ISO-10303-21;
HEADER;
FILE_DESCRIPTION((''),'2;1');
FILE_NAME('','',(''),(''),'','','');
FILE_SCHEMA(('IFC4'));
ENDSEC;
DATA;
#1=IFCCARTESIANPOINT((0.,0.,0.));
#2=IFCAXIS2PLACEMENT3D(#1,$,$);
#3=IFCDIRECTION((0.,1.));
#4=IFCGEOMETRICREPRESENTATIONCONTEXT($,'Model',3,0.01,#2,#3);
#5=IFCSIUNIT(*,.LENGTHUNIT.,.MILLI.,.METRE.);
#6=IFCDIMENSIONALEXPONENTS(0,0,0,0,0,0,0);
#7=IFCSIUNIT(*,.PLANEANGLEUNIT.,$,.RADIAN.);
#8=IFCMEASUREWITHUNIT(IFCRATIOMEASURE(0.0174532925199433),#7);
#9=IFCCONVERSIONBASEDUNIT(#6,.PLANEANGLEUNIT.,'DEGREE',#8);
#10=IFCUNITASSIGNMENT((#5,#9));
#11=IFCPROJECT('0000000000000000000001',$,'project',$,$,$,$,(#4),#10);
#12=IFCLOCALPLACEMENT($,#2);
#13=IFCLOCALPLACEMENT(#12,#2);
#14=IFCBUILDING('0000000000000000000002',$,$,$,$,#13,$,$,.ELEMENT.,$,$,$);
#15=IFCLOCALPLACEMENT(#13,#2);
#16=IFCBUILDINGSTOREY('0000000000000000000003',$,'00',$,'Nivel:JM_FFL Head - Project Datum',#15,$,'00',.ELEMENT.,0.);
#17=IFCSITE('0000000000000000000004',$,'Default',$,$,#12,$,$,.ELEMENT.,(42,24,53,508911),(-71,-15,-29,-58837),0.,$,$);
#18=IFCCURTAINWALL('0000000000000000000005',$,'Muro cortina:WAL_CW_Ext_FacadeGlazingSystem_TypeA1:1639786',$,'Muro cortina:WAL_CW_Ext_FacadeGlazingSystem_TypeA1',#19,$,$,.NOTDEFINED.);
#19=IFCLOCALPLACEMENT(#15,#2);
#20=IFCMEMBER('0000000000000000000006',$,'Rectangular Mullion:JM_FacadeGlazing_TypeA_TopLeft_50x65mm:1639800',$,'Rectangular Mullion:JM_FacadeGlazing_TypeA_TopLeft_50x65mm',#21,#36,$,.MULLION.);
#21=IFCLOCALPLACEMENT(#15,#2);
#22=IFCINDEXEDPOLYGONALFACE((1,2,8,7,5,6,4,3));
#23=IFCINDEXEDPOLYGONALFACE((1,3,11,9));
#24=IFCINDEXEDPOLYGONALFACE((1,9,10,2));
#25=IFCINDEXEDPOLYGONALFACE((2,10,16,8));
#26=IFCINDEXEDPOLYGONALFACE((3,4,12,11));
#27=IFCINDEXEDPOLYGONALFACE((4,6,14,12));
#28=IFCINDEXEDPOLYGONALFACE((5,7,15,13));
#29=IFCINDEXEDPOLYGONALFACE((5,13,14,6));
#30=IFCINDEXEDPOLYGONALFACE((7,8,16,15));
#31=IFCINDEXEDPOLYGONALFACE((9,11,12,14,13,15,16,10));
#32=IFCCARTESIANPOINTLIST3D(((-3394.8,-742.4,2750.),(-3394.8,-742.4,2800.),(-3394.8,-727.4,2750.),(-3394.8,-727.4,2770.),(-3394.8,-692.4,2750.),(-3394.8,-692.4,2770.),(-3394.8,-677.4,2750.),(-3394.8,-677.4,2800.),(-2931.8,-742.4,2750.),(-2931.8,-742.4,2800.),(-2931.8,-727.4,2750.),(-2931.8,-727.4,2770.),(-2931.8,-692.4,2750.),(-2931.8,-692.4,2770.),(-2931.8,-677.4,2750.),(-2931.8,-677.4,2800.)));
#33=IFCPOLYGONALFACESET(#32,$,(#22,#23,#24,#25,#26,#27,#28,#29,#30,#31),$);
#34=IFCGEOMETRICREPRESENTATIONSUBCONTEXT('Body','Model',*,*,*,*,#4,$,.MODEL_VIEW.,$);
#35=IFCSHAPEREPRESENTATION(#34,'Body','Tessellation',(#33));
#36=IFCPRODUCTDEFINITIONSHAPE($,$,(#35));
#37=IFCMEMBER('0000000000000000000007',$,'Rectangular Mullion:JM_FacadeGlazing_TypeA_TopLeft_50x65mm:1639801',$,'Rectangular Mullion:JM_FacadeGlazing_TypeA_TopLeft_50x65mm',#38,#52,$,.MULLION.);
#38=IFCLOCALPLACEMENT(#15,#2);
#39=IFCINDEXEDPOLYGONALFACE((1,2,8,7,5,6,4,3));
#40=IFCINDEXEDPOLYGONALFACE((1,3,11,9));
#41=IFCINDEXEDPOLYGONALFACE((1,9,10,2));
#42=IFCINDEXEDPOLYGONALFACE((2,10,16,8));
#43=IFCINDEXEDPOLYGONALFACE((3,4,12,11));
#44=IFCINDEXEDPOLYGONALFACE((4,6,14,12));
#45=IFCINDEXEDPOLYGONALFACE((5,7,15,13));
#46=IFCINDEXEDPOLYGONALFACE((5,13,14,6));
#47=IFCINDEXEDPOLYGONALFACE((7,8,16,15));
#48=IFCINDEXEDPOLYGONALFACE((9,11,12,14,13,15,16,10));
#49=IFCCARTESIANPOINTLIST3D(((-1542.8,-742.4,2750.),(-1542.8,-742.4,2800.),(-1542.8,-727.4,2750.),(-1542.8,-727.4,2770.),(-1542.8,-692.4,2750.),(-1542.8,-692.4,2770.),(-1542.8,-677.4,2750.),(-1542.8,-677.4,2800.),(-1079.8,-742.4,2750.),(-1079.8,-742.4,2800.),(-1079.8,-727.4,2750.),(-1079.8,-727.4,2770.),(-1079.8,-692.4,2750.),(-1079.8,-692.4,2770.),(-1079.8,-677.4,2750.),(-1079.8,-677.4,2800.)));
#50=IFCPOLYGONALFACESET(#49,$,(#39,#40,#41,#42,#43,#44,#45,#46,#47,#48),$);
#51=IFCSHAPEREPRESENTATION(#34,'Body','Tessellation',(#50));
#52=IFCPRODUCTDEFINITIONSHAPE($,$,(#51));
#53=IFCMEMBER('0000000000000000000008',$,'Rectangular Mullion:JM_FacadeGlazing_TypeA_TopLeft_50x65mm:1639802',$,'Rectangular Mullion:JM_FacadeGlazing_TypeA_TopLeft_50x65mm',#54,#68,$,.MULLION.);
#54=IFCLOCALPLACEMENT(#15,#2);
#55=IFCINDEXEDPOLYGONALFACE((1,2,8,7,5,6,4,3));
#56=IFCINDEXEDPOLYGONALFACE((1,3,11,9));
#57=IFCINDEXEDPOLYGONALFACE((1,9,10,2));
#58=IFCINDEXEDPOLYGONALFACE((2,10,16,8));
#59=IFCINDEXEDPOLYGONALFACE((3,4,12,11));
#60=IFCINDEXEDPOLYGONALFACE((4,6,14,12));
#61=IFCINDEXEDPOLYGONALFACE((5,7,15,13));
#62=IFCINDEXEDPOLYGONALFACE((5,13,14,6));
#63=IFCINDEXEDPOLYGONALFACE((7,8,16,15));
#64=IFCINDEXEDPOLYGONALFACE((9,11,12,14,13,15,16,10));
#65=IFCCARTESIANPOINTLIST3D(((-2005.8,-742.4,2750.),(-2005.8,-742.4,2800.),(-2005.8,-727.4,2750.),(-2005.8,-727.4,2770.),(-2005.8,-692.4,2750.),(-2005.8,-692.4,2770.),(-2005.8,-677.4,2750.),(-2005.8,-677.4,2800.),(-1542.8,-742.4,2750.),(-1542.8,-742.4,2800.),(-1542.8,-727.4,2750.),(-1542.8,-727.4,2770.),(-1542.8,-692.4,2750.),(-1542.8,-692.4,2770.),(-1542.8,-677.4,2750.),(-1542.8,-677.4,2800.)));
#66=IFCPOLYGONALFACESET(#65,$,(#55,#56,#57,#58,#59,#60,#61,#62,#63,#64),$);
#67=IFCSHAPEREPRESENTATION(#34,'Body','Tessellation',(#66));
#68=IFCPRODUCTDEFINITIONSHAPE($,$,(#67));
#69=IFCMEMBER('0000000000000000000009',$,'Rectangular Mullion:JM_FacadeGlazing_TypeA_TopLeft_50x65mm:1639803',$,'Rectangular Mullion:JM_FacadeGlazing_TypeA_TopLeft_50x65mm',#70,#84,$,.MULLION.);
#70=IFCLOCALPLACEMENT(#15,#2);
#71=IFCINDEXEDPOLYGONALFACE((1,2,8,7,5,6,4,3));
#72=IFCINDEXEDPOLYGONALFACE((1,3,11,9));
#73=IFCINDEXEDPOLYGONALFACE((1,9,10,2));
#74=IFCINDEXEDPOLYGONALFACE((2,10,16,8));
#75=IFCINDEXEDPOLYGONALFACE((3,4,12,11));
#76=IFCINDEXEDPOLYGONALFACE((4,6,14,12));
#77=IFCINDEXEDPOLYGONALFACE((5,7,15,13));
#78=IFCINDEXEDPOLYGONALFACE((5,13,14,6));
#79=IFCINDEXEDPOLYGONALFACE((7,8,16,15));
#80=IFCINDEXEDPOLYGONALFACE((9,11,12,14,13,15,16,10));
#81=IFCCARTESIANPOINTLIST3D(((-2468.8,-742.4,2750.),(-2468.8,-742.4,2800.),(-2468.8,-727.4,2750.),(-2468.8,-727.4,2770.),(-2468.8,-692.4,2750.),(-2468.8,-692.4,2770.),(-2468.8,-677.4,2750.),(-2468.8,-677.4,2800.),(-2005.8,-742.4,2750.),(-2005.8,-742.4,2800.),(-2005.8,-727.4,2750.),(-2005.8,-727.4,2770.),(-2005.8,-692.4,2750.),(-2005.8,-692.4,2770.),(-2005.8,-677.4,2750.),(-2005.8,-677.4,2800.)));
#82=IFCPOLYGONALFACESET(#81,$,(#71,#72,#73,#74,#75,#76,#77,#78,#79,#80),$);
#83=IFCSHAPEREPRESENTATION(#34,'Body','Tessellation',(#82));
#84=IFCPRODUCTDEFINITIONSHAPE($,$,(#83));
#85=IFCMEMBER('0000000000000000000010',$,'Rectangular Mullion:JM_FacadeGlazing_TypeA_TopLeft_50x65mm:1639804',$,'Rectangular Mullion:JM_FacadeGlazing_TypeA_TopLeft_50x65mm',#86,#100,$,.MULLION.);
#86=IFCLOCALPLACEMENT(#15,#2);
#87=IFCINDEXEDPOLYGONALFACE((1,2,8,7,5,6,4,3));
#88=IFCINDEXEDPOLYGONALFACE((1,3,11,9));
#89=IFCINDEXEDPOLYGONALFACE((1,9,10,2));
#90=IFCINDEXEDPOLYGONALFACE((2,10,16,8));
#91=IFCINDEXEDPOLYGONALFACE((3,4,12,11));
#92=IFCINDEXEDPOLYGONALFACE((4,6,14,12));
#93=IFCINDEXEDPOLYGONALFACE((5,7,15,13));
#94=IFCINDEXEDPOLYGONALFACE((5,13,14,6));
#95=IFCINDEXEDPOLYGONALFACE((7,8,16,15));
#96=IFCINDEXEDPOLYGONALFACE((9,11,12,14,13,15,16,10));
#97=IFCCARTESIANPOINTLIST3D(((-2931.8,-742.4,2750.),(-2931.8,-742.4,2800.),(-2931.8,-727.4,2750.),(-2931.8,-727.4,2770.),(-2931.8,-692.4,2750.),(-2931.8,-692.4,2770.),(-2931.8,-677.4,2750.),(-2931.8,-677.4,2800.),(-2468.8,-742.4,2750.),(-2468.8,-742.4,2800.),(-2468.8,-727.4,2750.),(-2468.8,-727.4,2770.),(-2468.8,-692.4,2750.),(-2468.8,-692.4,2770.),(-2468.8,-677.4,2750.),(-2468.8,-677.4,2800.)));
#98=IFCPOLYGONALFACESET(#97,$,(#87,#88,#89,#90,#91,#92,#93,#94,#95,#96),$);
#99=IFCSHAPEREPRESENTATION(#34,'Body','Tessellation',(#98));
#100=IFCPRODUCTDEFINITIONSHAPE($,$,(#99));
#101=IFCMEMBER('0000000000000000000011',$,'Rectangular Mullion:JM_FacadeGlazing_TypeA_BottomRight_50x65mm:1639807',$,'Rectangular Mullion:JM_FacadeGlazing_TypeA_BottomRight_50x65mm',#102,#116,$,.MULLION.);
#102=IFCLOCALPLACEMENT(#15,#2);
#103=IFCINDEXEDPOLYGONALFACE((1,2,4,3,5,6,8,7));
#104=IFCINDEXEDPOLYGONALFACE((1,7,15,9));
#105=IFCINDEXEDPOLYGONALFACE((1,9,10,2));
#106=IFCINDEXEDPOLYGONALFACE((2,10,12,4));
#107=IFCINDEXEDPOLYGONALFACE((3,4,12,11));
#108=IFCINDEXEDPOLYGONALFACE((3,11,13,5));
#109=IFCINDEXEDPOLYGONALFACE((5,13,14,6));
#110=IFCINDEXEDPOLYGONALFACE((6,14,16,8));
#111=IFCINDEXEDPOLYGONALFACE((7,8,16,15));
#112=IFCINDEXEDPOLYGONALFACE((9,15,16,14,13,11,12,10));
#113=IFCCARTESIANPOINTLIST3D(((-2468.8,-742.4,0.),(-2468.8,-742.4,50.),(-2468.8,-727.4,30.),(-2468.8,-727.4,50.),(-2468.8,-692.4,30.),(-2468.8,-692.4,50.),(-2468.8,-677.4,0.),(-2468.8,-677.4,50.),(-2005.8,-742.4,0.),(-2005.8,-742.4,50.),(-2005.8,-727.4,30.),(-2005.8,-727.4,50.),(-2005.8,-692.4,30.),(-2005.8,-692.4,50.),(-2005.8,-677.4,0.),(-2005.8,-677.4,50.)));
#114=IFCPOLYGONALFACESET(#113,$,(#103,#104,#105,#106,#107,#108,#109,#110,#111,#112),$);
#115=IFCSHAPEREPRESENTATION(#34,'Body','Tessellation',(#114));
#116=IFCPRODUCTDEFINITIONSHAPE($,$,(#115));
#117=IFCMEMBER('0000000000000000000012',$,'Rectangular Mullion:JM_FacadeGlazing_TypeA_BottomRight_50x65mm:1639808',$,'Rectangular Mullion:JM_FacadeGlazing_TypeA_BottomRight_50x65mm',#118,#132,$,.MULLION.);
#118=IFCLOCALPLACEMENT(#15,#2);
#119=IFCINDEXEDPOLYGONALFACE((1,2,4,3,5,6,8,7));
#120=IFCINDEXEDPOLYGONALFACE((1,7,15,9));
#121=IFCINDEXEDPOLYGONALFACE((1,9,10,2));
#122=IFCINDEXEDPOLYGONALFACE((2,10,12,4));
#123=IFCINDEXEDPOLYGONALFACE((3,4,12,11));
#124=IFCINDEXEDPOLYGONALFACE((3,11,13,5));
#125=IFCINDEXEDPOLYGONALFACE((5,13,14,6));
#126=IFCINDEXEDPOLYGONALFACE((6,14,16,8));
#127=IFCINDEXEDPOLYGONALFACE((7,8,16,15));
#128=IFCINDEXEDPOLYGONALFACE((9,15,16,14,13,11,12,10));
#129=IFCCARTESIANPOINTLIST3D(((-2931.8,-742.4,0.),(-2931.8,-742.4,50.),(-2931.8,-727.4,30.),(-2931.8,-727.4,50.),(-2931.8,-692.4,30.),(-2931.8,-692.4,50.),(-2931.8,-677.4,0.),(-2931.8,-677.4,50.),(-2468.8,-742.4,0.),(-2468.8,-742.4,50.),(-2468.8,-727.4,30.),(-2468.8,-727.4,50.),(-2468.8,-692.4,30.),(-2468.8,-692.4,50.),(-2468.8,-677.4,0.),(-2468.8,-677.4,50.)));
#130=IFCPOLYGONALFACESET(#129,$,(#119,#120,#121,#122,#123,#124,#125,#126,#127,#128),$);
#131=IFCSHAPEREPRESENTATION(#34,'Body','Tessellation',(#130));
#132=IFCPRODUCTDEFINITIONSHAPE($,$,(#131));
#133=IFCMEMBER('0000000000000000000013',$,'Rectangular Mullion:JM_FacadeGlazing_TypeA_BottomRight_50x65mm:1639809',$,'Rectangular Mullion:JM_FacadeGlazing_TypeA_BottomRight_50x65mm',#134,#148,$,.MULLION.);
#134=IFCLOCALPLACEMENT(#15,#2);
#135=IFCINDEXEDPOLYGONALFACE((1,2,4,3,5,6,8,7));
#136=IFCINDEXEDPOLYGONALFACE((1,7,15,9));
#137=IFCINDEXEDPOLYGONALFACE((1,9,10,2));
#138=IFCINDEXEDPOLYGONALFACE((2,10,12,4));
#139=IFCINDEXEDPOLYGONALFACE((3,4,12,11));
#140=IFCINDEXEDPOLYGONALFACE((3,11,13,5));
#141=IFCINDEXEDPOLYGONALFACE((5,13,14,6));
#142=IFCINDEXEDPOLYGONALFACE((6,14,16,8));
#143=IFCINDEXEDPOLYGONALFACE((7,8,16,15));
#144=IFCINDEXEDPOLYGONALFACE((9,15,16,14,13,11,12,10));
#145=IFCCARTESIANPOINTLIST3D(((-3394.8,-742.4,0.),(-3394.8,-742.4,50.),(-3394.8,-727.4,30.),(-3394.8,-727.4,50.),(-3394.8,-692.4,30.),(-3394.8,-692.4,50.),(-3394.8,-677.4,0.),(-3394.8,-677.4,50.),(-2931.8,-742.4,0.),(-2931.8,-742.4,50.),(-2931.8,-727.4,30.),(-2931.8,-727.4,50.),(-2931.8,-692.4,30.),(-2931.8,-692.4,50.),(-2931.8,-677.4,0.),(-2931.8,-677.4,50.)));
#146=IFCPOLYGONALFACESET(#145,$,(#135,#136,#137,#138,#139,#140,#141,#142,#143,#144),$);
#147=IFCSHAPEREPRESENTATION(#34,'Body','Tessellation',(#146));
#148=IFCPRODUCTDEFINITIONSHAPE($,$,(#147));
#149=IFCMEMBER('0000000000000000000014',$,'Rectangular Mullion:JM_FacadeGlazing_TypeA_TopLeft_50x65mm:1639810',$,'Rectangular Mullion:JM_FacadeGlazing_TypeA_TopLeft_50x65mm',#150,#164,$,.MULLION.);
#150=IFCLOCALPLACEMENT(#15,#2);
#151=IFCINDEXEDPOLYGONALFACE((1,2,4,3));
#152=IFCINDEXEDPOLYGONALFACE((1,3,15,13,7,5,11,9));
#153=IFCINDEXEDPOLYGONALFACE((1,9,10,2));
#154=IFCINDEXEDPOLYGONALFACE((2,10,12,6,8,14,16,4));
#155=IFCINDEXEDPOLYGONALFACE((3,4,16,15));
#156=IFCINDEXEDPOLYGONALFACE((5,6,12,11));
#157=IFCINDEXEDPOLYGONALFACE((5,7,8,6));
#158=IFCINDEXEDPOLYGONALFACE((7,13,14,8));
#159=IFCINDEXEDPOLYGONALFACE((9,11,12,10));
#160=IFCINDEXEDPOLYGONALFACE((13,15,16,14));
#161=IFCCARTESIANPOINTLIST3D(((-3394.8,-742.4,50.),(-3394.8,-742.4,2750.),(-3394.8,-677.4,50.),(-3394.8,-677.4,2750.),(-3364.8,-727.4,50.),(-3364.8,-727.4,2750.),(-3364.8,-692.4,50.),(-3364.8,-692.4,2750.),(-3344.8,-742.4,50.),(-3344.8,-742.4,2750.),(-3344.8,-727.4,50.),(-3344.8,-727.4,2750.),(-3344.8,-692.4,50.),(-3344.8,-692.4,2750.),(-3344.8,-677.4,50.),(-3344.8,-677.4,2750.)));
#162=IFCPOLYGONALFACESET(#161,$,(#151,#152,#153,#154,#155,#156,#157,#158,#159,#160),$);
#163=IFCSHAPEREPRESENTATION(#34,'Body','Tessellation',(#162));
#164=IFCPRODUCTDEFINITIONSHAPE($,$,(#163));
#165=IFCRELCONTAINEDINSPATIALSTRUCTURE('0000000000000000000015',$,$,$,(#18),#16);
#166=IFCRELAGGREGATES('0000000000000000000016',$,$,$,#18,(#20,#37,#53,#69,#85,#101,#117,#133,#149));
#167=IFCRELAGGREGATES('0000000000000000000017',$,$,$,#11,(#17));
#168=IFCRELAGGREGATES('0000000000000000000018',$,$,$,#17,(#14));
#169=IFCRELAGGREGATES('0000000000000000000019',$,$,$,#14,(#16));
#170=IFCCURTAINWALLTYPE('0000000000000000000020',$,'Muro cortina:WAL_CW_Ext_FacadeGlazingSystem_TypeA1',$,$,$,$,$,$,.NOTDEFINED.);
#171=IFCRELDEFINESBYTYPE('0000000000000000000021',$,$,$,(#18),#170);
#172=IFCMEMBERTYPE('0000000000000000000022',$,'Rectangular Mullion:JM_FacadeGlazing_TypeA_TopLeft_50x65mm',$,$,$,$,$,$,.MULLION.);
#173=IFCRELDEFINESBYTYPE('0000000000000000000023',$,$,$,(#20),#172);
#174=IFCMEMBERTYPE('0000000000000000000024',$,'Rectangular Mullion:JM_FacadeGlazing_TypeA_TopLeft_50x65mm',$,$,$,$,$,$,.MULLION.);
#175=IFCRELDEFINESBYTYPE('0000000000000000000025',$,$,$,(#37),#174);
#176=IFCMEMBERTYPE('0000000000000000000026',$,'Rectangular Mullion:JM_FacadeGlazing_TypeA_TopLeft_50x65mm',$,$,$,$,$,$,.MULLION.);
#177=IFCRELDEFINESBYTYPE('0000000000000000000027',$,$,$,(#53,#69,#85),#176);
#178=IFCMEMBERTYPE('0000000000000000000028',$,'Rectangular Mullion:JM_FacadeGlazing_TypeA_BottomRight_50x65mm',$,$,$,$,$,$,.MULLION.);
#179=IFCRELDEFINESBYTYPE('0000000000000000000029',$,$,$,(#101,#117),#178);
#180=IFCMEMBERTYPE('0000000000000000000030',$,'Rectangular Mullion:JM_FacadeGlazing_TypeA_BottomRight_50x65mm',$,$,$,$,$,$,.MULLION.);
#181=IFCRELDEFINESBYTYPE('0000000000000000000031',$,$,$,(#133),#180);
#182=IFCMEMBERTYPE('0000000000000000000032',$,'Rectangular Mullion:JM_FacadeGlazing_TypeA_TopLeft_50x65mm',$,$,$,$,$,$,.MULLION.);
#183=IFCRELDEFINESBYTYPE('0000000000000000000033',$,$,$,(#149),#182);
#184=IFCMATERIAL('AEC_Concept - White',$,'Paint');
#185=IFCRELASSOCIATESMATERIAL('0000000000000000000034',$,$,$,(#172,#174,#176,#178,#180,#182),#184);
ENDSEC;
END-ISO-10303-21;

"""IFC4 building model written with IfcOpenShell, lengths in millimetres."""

from ifc_helpers import new_model, entity, si_unit, converted_unit, direction, frame, origin, place, context, subcontext, project, spatial, indexed_curve, outline, extrude, source, transform, mapped, material, type_object, type_shapes, element, aggregate, save


model = new_model("IFC4")

# Units and contexts
model_context = context("Model", 3, precision=0.01, world=origin(), true_north=direction((0.0, 1.0)))
body_context = subcontext(model_context, "Body", "Model", "MODEL_VIEW")
ifc_project = project(units=[si_unit("LENGTHUNIT", "METRE", prefix="MILLI"), converted_unit("PLANEANGLEUNIT", "DEGREE", entity("IfcRatioMeasure", 0.0174532925199433), si_unit("PLANEANGLEUNIT", "RADIAN"), dimensions=[0, 0, 0, 0, 0, 0, 0])], contexts=[model_context])

# Site, building, storey
site_placement = place(None, origin())
site = spatial("IfcSite", under=ifc_project, at=site_placement, Name="Default", CompositionType="ELEMENT", RefLatitude=(42, 24, 53, 508911), RefLongitude=(-71, -15, -29, -58837), RefElevation=0.0)
building_placement = place(site_placement, origin())
building = spatial("IfcBuilding", under=site, at=building_placement, CompositionType="ELEMENT")
storey_placement = place(building_placement, origin())
storey = spatial("IfcBuildingStorey", under=building, at=storey_placement, Name="00", ObjectType="Nivel:JM_FFL Head - Project Datum", LongName="00", CompositionType="ELEMENT", Elevation=0.0)

# Curtain wall, members
curtain_wall_type = type_object("IfcCurtainWallType", Name="Muro cortina:WAL_CW_Ext_FacadeGlazingSystem_TypeA1", PredefinedType="NOTDEFINED")
curtain_wall_1_placement = place(storey_placement, origin())
curtain_wall_1 = element("IfcCurtainWall", 1, at=curtain_wall_1_placement, inside=storey, type_object=curtain_wall_type, Name="Muro cortina:WAL_CW_Ext_FacadeGlazingSystem_TypeA1:1639786", ObjectType="Muro cortina:WAL_CW_Ext_FacadeGlazingSystem_TypeA1", PredefinedType="NOTDEFINED")
ifc_material_1 = material(Name="AEC_Concept - White", Category="Paint")
member_type_1 = type_object("IfcMemberType", Name="Rectangular Mullion:JM_FacadeGlazing_TypeA_TopLeft_50x65mm", PredefinedType="MULLION", material=ifc_material_1)
shared_shape_1 = source(origin(), body_context, "Body", "SweptSolid", [
    extrude(outline(indexed_curve([(-32.5, -17.5), (-17.5, -17.5), (-17.5, 2.5), (17.5, 2.5), (17.5, -17.5), (32.5, -17.5), (32.5, 32.5), (-32.5, 32.5), (-32.5, -17.5)], self_intersect=False)), frame((-32.5, -32.5, -463.0), z_axis=(0.0, 0.0, 1.0), x_axis=(0.0, -1.0, 0.0)), (0.0, 0.0, 1.0), 463.0),
])
type_shapes(member_type_1, [shared_shape_1])
member_1_placement = place(curtain_wall_1_placement, frame((-3394.8, -677.4, 2800.0), z_axis=(-1.0, 0.0, 0.0), x_axis=(0.0, 0.0, 1.0)))
member_1 = element("IfcMember", 2, at=member_1_placement, type_object=member_type_1, Name="Rectangular Mullion:JM_FacadeGlazing_TypeA_TopLeft_50x65mm:1639800", ObjectType="Rectangular Mullion:JM_FacadeGlazing_TypeA_TopLeft_50x65mm", PredefinedType="MULLION", context=body_context, shape_type="MappedRepresentation", body=[
    mapped(shared_shape_1, transform((0.0, 0.0, 0.0), scale=1.0)),
])
member_type_2 = type_object("IfcMemberType", Name="Rectangular Mullion:JM_FacadeGlazing_TypeA_TopLeft_50x65mm", PredefinedType="MULLION", material=ifc_material_1)
shared_shape_2 = source(origin(), body_context, "Body", "SweptSolid", [
    extrude(outline(indexed_curve([(-32.5, -17.5), (-17.5, -17.5), (-17.5, 2.5), (17.5, 2.5), (17.5, -17.5), (32.5, -17.5), (32.5, 32.5), (-32.5, 32.5), (-32.5, -17.5)], self_intersect=False)), frame((-32.5, -32.5, -463.0), z_axis=(0.0, 0.0, 1.0), x_axis=(0.0, -1.0, 0.0)), (0.0, 0.0, 1.0), 463.0),
])
type_shapes(member_type_2, [shared_shape_2])
member_2_placement = place(curtain_wall_1_placement, frame((-1542.8, -677.4, 2800.0), z_axis=(-1.0, 0.0, 0.0), x_axis=(0.0, 0.0, 1.0)))
member_2 = element("IfcMember", 3, at=member_2_placement, type_object=member_type_2, Name="Rectangular Mullion:JM_FacadeGlazing_TypeA_TopLeft_50x65mm:1639801", ObjectType="Rectangular Mullion:JM_FacadeGlazing_TypeA_TopLeft_50x65mm", PredefinedType="MULLION", context=body_context, shape_type="MappedRepresentation", body=[
    mapped(shared_shape_2, transform((0.0, 0.0, 0.0), scale=1.0)),
])
member_type_3 = type_object("IfcMemberType", Name="Rectangular Mullion:JM_FacadeGlazing_TypeA_TopLeft_50x65mm", PredefinedType="MULLION", material=ifc_material_1)
shared_shape_3 = source(origin(), body_context, "Body", "SweptSolid", [
    extrude(outline(indexed_curve([(-32.5, -17.5), (-17.5, -17.5), (-17.5, 2.5), (17.5, 2.5), (17.5, -17.5), (32.5, -17.5), (32.5, 32.5), (-32.5, 32.5), (-32.5, -17.5)], self_intersect=False)), frame((-32.5, -32.5, -463.0), z_axis=(0.0, 0.0, 1.0), x_axis=(0.0, -1.0, 0.0)), (0.0, 0.0, 1.0), 463.0),
])
type_shapes(member_type_3, [shared_shape_3])
member_3_placement = place(curtain_wall_1_placement, frame((-2005.8, -677.4, 2800.0), z_axis=(-1.0, 0.0, 0.0), x_axis=(0.0, 0.0, 1.0)))
member_3 = element("IfcMember", 4, at=member_3_placement, type_object=member_type_3, Name="Rectangular Mullion:JM_FacadeGlazing_TypeA_TopLeft_50x65mm:1639802", ObjectType="Rectangular Mullion:JM_FacadeGlazing_TypeA_TopLeft_50x65mm", PredefinedType="MULLION", context=body_context, shape_type="MappedRepresentation", body=[
    mapped(shared_shape_3, transform((0.0, 0.0, 0.0), scale=1.0)),
])
member_4_placement = place(curtain_wall_1_placement, frame((-2468.8, -677.4, 2800.0), z_axis=(-1.0, 0.0, 0.0), x_axis=(0.0, 0.0, 1.0)))
member_4 = element("IfcMember", 5, at=member_4_placement, type_object=member_type_3, Name="Rectangular Mullion:JM_FacadeGlazing_TypeA_TopLeft_50x65mm:1639803", ObjectType="Rectangular Mullion:JM_FacadeGlazing_TypeA_TopLeft_50x65mm", PredefinedType="MULLION", context=body_context, shape_type="MappedRepresentation", body=[
    mapped(shared_shape_3, transform((0.0, 0.0, 0.0), scale=1.0)),
])
member_5_placement = place(curtain_wall_1_placement, frame((-2931.8, -677.4, 2800.0), z_axis=(-1.0, 0.0, 0.0), x_axis=(0.0, 0.0, 1.0)))
member_5 = element("IfcMember", 6, at=member_5_placement, type_object=member_type_3, Name="Rectangular Mullion:JM_FacadeGlazing_TypeA_TopLeft_50x65mm:1639804", ObjectType="Rectangular Mullion:JM_FacadeGlazing_TypeA_TopLeft_50x65mm", PredefinedType="MULLION", context=body_context, shape_type="MappedRepresentation", body=[
    mapped(shared_shape_3, transform((0.0, 0.0, 0.0), scale=1.0)),
])
member_type_4 = type_object("IfcMemberType", Name="Rectangular Mullion:JM_FacadeGlazing_TypeA_BottomRight_50x65mm", PredefinedType="MULLION", material=ifc_material_1)
shared_shape_4 = source(origin(), body_context, "Body", "SweptSolid", [
    extrude(outline(indexed_curve([(-32.5, -17.5), (-17.5, -17.5), (-17.5, 2.5), (17.5, 2.5), (17.5, -17.5), (32.5, -17.5), (32.5, 32.5), (-32.5, 32.5), (-32.5, -17.5)], self_intersect=False)), frame((-32.5, -32.5, -463.0), z_axis=(0.0, 0.0, 1.0), x_axis=(0.0, -1.0, 0.0)), (0.0, 0.0, 1.0), 463.0),
])
type_shapes(member_type_4, [shared_shape_4])
member_6_placement = place(curtain_wall_1_placement, frame((-2005.8, -677.4, 0.0), z_axis=(1.0, 0.0, 0.0), x_axis=(0.0, 0.0, -1.0)))
member_6 = element("IfcMember", 7, at=member_6_placement, type_object=member_type_4, Name="Rectangular Mullion:JM_FacadeGlazing_TypeA_BottomRight_50x65mm:1639807", ObjectType="Rectangular Mullion:JM_FacadeGlazing_TypeA_BottomRight_50x65mm", PredefinedType="MULLION", context=body_context, shape_type="MappedRepresentation", body=[
    mapped(shared_shape_4, transform((0.0, 0.0, 0.0), scale=1.0)),
])
member_7_placement = place(curtain_wall_1_placement, frame((-2468.8, -677.4, 0.0), z_axis=(1.0, 0.0, 0.0), x_axis=(0.0, 0.0, -1.0)))
member_7 = element("IfcMember", 8, at=member_7_placement, type_object=member_type_4, Name="Rectangular Mullion:JM_FacadeGlazing_TypeA_BottomRight_50x65mm:1639808", ObjectType="Rectangular Mullion:JM_FacadeGlazing_TypeA_BottomRight_50x65mm", PredefinedType="MULLION", context=body_context, shape_type="MappedRepresentation", body=[
    mapped(shared_shape_4, transform((0.0, 0.0, 0.0), scale=1.0)),
])
member_type_5 = type_object("IfcMemberType", Name="Rectangular Mullion:JM_FacadeGlazing_TypeA_BottomRight_50x65mm", PredefinedType="MULLION", material=ifc_material_1)
shared_shape_5 = source(origin(), body_context, "Body", "SweptSolid", [
    extrude(outline(indexed_curve([(-32.5, -17.5), (-17.5, -17.5), (-17.5, 2.5), (17.5, 2.5), (17.5, -17.5), (32.5, -17.5), (32.5, 32.5), (-32.5, 32.5), (-32.5, -17.5)], self_intersect=False)), frame((-32.5, -32.5, -463.0), z_axis=(0.0, 0.0, 1.0), x_axis=(0.0, -1.0, 0.0)), (0.0, 0.0, 1.0), 463.0),
])
type_shapes(member_type_5, [shared_shape_5])
member_8_placement = place(curtain_wall_1_placement, frame((-2931.8, -677.4, 0.0), z_axis=(1.0, 0.0, 0.0), x_axis=(0.0, 0.0, -1.0)))
member_8 = element("IfcMember", 9, at=member_8_placement, type_object=member_type_5, Name="Rectangular Mullion:JM_FacadeGlazing_TypeA_BottomRight_50x65mm:1639809", ObjectType="Rectangular Mullion:JM_FacadeGlazing_TypeA_BottomRight_50x65mm", PredefinedType="MULLION", context=body_context, shape_type="MappedRepresentation", body=[
    mapped(shared_shape_5, transform((0.0, 0.0, 0.0), scale=1.0)),
])
member_type_6 = type_object("IfcMemberType", Name="Rectangular Mullion:JM_FacadeGlazing_TypeA_TopLeft_50x65mm", PredefinedType="MULLION", material=ifc_material_1)
shared_shape_6 = source(origin(), body_context, "Body", "SweptSolid", [
    extrude(outline(indexed_curve([(-32.5, -17.5), (-17.5, -17.5), (-17.5, 2.5), (17.5, 2.5), (17.5, -17.5), (32.5, -17.5), (32.5, 32.5), (-32.5, 32.5), (-32.5, -17.5)], self_intersect=False)), frame((-32.5, -32.5, -2700.0), z_axis=(0.0, 0.0, 1.0), x_axis=(0.0, -1.0, 0.0)), (0.0, 0.0, 1.0), 2700.0),
])
type_shapes(member_type_6, [shared_shape_6])
member_9_placement = place(curtain_wall_1_placement, frame((-3394.8, -677.4, 50.0), z_axis=(0.0, 0.0, -1.0), x_axis=(-1.0, 0.0, 0.0)))
member_9 = element("IfcMember", 10, at=member_9_placement, type_object=member_type_6, Name="Rectangular Mullion:JM_FacadeGlazing_TypeA_TopLeft_50x65mm:1639810", ObjectType="Rectangular Mullion:JM_FacadeGlazing_TypeA_TopLeft_50x65mm", PredefinedType="MULLION", context=body_context, shape_type="MappedRepresentation", body=[
    mapped(shared_shape_6, transform((0.0, 0.0, 0.0), scale=1.0)),
])

aggregate(curtain_wall_1, [member_1, member_2, member_3, member_4, member_5, member_6, member_7, member_8, member_9])

save(model, "model.ifc")
